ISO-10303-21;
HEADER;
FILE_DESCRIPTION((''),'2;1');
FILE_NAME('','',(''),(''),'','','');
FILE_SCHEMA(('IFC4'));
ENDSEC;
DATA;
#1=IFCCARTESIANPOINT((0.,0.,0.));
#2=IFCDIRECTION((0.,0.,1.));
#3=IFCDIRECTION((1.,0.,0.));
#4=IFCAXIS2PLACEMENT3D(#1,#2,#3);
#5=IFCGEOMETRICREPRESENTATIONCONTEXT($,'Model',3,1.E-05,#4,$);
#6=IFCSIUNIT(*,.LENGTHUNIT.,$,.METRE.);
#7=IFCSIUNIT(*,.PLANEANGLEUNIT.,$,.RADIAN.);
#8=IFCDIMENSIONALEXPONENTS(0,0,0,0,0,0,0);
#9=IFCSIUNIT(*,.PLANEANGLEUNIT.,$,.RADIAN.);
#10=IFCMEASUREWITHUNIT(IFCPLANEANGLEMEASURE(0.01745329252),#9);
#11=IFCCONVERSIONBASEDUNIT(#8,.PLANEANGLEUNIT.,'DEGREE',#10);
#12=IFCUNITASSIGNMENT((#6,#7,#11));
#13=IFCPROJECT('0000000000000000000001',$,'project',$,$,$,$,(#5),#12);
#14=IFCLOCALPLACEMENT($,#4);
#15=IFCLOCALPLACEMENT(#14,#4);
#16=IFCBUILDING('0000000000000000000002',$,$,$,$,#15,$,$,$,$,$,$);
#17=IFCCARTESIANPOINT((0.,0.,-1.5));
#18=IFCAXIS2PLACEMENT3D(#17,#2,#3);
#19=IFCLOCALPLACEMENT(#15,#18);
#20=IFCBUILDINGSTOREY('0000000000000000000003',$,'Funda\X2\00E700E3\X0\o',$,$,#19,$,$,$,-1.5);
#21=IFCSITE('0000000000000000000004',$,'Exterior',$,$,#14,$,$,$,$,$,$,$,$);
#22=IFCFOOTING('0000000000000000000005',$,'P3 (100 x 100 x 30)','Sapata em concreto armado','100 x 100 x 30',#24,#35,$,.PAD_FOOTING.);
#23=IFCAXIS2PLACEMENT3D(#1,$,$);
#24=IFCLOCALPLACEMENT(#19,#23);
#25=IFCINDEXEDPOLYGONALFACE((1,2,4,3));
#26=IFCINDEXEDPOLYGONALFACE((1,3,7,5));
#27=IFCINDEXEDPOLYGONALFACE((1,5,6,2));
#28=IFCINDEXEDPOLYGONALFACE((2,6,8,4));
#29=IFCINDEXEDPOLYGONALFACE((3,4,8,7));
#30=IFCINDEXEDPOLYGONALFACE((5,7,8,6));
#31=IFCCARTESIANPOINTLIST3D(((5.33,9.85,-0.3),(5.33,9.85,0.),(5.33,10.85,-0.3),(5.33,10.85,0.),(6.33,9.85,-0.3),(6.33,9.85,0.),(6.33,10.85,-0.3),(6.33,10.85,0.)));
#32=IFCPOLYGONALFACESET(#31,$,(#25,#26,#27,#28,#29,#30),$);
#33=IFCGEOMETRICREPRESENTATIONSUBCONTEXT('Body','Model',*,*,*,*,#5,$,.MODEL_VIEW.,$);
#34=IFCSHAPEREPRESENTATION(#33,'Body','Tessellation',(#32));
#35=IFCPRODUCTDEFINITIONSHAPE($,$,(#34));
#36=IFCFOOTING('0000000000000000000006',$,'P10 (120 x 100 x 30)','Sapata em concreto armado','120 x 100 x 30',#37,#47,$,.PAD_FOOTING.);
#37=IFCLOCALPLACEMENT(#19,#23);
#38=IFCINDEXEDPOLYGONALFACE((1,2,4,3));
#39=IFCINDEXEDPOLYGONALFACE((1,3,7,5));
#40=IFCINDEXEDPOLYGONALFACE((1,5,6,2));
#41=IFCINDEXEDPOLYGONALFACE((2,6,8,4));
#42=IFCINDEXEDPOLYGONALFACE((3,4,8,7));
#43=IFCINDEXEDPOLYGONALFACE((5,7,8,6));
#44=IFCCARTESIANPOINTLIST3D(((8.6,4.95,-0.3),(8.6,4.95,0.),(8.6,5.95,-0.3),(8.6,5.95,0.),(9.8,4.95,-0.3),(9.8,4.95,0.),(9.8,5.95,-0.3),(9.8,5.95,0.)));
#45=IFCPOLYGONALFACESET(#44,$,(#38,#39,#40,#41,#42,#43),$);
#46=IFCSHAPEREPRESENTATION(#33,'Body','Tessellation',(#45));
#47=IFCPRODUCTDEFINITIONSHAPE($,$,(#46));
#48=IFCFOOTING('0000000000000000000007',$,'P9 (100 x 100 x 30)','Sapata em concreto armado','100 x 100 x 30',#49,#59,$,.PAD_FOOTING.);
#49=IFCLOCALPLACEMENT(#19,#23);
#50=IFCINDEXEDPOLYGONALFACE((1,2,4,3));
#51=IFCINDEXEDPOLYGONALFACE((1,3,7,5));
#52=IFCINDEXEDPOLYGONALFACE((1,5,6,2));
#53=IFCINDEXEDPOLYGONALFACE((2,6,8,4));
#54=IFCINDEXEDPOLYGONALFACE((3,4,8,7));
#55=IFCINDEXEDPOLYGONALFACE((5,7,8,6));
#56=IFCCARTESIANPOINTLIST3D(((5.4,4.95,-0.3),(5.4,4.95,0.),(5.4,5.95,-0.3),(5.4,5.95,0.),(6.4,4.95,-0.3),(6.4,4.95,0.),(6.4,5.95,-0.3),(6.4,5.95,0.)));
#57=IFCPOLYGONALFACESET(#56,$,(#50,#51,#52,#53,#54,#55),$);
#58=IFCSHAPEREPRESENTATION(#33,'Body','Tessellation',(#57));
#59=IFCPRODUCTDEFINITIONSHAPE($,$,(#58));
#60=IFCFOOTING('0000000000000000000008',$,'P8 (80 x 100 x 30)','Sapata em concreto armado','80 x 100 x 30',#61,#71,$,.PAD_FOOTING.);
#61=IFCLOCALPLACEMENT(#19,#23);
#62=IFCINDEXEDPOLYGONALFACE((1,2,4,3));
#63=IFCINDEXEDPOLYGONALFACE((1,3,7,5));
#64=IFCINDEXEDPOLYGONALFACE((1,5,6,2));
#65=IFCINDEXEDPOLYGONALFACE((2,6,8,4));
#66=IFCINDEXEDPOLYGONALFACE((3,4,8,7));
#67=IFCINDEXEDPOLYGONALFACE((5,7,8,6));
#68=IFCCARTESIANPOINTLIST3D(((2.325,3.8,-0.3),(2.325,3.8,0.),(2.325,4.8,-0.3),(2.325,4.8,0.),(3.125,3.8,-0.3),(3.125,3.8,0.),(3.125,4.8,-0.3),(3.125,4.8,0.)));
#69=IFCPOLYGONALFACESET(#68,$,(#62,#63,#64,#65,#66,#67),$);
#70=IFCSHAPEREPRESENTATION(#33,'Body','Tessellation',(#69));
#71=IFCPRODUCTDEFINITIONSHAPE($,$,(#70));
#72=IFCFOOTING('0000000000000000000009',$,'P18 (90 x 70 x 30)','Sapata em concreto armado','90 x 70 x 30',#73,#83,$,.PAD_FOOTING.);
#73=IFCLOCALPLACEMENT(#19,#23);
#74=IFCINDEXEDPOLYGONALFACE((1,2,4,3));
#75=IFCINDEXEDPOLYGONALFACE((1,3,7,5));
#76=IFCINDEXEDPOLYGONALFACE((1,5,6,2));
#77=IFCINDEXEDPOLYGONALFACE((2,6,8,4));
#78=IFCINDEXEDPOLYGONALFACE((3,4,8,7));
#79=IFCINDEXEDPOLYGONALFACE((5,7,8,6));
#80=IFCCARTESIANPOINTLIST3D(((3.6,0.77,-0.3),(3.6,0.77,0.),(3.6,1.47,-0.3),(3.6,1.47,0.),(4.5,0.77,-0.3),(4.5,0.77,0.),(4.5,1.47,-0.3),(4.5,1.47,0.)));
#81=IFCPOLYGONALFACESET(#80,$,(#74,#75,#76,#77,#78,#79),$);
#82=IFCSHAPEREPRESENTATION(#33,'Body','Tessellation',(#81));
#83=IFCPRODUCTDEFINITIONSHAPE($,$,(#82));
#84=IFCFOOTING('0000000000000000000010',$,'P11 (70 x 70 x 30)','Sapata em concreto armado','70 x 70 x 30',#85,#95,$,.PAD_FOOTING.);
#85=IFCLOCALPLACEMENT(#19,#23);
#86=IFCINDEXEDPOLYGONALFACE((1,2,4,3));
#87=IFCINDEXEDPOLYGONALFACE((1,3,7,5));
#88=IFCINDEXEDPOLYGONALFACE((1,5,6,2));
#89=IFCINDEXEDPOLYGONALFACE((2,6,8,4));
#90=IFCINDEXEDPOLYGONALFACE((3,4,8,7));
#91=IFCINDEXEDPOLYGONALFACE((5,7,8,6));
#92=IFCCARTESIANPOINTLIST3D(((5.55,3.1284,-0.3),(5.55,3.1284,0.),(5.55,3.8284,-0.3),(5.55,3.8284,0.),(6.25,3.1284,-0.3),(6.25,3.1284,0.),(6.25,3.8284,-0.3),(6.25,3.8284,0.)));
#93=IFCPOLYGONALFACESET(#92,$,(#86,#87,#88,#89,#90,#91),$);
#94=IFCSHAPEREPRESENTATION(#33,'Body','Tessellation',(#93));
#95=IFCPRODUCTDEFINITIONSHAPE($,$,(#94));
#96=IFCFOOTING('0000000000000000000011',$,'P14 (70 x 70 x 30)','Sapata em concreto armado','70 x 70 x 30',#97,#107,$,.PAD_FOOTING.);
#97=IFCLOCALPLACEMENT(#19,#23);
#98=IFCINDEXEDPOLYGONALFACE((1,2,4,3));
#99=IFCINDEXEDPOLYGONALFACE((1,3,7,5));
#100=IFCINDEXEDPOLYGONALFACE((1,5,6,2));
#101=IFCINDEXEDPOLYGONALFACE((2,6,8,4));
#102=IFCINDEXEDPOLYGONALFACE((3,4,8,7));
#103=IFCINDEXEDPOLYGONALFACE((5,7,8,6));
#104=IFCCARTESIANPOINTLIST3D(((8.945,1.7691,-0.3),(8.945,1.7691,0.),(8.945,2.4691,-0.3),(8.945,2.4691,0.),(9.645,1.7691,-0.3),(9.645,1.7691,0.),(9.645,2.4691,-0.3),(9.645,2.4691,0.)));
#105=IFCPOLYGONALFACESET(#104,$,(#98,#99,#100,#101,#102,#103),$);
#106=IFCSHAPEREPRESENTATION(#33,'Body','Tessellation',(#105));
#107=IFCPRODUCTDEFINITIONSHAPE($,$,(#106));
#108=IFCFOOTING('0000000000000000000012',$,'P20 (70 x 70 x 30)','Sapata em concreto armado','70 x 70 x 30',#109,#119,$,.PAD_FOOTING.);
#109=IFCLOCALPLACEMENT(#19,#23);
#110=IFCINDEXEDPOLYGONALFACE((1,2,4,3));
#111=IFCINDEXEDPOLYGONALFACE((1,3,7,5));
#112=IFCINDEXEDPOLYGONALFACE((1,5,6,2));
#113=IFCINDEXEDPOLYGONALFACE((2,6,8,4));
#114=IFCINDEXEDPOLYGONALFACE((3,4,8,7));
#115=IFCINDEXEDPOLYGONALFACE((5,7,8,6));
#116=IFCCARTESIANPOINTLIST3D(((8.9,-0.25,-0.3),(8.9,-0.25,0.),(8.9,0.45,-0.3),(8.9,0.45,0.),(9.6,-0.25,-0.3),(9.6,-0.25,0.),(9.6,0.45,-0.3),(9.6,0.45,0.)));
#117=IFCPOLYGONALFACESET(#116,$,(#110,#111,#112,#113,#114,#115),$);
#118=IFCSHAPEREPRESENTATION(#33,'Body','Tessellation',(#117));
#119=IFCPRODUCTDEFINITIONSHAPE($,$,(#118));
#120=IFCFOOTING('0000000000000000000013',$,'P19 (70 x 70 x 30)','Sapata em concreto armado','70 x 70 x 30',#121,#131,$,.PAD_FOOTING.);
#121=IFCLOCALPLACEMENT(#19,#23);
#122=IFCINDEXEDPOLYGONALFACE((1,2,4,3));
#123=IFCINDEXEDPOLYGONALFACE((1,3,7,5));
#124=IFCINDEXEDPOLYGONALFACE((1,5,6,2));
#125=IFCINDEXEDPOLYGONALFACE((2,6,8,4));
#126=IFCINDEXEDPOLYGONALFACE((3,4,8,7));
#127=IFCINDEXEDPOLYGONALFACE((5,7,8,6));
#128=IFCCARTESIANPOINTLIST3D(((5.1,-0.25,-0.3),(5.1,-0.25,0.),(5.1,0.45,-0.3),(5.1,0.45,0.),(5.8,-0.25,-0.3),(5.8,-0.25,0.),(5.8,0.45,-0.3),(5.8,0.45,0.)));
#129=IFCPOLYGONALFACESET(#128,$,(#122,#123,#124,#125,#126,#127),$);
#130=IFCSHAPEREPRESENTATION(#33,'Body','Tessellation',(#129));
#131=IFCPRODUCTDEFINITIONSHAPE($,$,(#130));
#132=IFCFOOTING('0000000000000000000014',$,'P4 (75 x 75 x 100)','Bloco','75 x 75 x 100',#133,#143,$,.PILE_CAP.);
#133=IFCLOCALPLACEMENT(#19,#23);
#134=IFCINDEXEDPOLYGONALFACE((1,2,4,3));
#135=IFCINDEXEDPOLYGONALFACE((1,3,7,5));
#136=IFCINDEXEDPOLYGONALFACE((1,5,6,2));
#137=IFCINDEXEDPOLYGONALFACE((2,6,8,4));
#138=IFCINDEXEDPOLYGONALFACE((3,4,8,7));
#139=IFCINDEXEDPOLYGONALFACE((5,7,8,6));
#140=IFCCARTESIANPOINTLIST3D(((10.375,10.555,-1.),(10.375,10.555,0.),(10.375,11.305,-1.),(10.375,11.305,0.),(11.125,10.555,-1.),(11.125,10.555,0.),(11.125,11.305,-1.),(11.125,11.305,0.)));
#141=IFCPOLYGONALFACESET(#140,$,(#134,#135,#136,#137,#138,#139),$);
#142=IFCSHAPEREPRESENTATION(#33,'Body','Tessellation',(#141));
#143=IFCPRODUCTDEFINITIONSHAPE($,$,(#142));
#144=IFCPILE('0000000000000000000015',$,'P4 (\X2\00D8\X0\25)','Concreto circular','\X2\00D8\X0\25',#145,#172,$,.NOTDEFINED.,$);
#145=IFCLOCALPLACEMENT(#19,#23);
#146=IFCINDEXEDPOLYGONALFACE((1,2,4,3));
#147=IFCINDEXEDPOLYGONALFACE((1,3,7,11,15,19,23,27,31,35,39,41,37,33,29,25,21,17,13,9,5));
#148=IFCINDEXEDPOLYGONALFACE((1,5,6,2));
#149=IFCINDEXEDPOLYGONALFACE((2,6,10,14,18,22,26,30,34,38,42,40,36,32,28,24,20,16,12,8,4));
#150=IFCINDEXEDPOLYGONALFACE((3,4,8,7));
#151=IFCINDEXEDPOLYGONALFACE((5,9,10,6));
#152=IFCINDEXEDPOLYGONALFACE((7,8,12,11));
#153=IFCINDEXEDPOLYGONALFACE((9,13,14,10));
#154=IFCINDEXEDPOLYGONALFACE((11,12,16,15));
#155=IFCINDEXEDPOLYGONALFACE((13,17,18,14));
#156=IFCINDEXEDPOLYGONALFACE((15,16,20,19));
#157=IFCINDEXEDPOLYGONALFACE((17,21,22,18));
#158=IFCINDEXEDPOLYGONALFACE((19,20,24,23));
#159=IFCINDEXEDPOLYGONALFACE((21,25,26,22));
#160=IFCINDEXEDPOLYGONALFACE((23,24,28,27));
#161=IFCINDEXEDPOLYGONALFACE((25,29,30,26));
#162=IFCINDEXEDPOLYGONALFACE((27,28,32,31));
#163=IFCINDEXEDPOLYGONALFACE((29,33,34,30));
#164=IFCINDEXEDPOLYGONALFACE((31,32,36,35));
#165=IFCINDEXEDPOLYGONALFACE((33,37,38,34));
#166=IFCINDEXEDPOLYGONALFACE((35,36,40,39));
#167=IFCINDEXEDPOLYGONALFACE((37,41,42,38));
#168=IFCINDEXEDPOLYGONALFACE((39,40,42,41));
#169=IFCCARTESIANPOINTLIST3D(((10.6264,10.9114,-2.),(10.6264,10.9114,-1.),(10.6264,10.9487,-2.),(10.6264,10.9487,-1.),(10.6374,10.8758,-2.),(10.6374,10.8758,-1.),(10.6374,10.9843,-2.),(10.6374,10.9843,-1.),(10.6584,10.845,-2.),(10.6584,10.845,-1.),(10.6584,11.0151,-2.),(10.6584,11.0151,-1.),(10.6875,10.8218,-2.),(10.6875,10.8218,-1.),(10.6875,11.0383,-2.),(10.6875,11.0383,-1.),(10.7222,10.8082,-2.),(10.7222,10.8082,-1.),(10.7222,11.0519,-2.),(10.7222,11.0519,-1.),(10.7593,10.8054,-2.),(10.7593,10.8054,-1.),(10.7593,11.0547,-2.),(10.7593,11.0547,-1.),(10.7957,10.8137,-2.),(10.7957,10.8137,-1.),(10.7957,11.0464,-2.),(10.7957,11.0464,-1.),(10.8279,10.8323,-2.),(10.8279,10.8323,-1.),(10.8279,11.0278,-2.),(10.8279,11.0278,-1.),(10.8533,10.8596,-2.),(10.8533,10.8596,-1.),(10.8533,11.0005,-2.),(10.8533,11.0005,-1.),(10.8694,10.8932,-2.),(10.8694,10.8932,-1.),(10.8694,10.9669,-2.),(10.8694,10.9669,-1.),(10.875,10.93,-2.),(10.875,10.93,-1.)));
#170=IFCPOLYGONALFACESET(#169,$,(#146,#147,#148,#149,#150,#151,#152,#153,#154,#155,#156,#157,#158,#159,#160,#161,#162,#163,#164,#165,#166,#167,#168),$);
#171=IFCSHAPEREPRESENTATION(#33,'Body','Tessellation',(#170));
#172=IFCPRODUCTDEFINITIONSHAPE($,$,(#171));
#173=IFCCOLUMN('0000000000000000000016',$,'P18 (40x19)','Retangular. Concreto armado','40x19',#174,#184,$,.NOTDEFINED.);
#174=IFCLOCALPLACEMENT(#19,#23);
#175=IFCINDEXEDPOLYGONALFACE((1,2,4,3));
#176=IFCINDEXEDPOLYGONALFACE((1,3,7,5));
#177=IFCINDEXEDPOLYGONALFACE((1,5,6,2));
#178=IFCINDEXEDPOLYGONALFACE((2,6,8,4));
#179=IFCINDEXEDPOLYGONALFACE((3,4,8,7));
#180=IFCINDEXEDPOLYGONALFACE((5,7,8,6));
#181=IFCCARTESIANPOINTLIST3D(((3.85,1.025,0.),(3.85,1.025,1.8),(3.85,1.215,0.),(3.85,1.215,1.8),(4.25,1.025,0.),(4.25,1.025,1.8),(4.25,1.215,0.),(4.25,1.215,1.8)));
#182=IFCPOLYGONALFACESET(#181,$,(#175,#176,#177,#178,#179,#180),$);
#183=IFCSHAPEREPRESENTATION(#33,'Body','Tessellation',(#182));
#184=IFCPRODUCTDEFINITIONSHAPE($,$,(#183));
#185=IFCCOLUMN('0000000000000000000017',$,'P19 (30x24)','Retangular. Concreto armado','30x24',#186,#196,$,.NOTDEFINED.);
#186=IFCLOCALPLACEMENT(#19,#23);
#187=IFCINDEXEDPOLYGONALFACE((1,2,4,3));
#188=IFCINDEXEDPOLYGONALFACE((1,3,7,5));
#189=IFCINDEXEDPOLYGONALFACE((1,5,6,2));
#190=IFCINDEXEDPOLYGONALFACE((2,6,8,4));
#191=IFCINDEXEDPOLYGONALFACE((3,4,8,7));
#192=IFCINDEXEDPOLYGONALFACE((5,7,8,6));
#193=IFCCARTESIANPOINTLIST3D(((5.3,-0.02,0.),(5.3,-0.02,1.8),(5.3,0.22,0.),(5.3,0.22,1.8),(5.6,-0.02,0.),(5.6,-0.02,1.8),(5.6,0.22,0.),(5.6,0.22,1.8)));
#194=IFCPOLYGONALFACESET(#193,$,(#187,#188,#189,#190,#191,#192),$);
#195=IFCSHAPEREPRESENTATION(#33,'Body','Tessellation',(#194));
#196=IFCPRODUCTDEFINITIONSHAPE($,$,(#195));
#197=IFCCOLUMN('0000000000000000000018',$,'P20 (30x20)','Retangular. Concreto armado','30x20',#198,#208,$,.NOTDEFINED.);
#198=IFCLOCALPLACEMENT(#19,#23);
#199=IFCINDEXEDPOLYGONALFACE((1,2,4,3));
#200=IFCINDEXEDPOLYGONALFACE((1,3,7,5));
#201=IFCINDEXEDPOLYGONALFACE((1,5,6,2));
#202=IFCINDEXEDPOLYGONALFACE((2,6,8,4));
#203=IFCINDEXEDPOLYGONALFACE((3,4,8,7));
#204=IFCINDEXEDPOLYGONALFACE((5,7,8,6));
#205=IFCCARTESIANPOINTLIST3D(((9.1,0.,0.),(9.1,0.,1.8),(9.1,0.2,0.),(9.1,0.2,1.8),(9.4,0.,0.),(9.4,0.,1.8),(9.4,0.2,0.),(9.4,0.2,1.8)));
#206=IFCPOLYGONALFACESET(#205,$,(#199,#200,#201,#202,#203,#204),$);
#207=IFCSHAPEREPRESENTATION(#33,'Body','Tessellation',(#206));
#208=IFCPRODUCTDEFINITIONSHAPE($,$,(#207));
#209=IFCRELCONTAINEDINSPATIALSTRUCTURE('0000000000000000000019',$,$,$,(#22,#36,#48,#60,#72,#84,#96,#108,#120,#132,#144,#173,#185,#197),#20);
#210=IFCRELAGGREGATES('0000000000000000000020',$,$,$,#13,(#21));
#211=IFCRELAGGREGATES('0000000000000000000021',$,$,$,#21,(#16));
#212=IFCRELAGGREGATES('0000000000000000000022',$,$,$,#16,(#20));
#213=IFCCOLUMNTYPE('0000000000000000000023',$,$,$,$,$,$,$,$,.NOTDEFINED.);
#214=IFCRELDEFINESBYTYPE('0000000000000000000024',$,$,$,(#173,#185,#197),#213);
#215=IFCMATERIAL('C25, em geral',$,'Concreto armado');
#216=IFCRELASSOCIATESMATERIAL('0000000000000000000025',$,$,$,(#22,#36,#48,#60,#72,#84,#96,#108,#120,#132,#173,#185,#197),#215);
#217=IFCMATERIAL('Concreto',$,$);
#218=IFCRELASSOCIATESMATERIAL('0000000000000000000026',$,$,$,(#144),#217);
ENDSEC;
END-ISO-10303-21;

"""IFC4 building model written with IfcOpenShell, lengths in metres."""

from ifc_helpers import new_model, entity, si_unit, converted_unit, frame, frame_2d, origin_with_axes, origin_2d_with_axis, place, context, subcontext, project, spatial, rectangle, circle, extrude, material, type_object, element, save


model = new_model("IFC4")

# Units and contexts
model_context = context("Model", 3, precision=1e-05, world=origin_with_axes())
body_context = subcontext(model_context, "Body", "Model", "MODEL_VIEW")
ifc_project = project(units=[si_unit("LENGTHUNIT", "METRE"), si_unit("PLANEANGLEUNIT", "RADIAN"), converted_unit("PLANEANGLEUNIT", "DEGREE", entity("IfcPlaneAngleMeasure", 0.01745329252), si_unit("PLANEANGLEUNIT", "RADIAN"), dimensions=[0, 0, 0, 0, 0, 0, 0])], contexts=[model_context])

# Site, building, storey
site_placement = place(None, origin_with_axes())
site = spatial("IfcSite", under=ifc_project, at=site_placement, Name="Exterior")
building_placement = place(site_placement, origin_with_axes())
building = spatial("IfcBuilding", under=site, at=building_placement)
storey_placement = place(building_placement, frame((0.0, 0.0, -1.5), z_axis=(0.0, 0.0, 1.0), x_axis=(1.0, 0.0, 0.0)))
storey = spatial("IfcBuildingStorey", under=building, at=storey_placement, Name="Fundação", Elevation=-1.5)

# Footings
ifc_material_1 = material(Name="C25, em geral", Category="Concreto armado")
footing_1_placement = place(storey_placement, frame((5.83, 10.35, -0.3), z_axis=(0.0, 0.0, 1.0), x_axis=(1.0, 0.0, 0.0)))
element("IfcFooting", 1, at=footing_1_placement, inside=storey, material=ifc_material_1, Name="P3 (100 x 100 x 30)", Description="Sapata em concreto armado", ObjectType="100 x 100 x 30", PredefinedType="PAD_FOOTING", context=body_context, shape_type="SweptSolid", body=[
    extrude(rectangle(XDim=1.0, YDim=1.0, at=origin_2d_with_axis()), origin_with_axes(), (0.0, 0.0, 1.0), 0.3),
])
footing_2_placement = place(storey_placement, frame((9.2, 5.45, -0.3), z_axis=(0.0, 0.0, 1.0), x_axis=(1.0, 0.0, 0.0)))
element("IfcFooting", 2, at=footing_2_placement, inside=storey, material=ifc_material_1, Name="P10 (120 x 100 x 30)", Description="Sapata em concreto armado", ObjectType="120 x 100 x 30", PredefinedType="PAD_FOOTING", context=body_context, shape_type="SweptSolid", body=[
    extrude(rectangle(XDim=1.2, YDim=1.0, at=origin_2d_with_axis()), origin_with_axes(), (0.0, 0.0, 1.0), 0.3),
])
footing_3_placement = place(storey_placement, frame((5.9, 5.45, -0.3), z_axis=(0.0, 0.0, 1.0), x_axis=(1.0, 0.0, 0.0)))
element("IfcFooting", 3, at=footing_3_placement, inside=storey, material=ifc_material_1, Name="P9 (100 x 100 x 30)", Description="Sapata em concreto armado", ObjectType="100 x 100 x 30", PredefinedType="PAD_FOOTING", context=body_context, shape_type="SweptSolid", body=[
    extrude(rectangle(XDim=1.0, YDim=1.0, at=origin_2d_with_axis()), origin_with_axes(), (0.0, 0.0, 1.0), 0.3),
])
footing_4_placement = place(storey_placement, frame((2.725, 4.3, -0.3), z_axis=(0.0, 0.0, 1.0), x_axis=(1.0, 0.0, 0.0)))
element("IfcFooting", 4, at=footing_4_placement, inside=storey, material=ifc_material_1, Name="P8 (80 x 100 x 30)", Description="Sapata em concreto armado", ObjectType="80 x 100 x 30", PredefinedType="PAD_FOOTING", context=body_context, shape_type="SweptSolid", body=[
    extrude(rectangle(XDim=0.8, YDim=1.0, at=origin_2d_with_axis()), origin_with_axes(), (0.0, 0.0, 1.0), 0.3),
])
footing_5_placement = place(storey_placement, frame((4.05, 1.12, -0.3), z_axis=(0.0, 0.0, 1.0), x_axis=(1.0, 0.0, 0.0)))
element("IfcFooting", 5, at=footing_5_placement, inside=storey, material=ifc_material_1, Name="P18 (90 x 70 x 30)", Description="Sapata em concreto armado", ObjectType="90 x 70 x 30", PredefinedType="PAD_FOOTING", context=body_context, shape_type="SweptSolid", body=[
    extrude(rectangle(XDim=0.9, YDim=0.7, at=origin_2d_with_axis()), origin_with_axes(), (0.0, 0.0, 1.0), 0.3),
])
for number, where, z_axis, x_axis, name in (
    (6, (5.9, 3.4784, -0.3), (0.0, 0.0, 1.0), (1.0, 0.0, 0.0), "P11 (70 x 70 x 30)"),
    (7, (9.295, 2.1191, -0.3), (0.0, 0.0, 1.0), (1.0, 0.0, 0.0), "P14 (70 x 70 x 30)"),
    (8, (9.25, 0.1, -0.3), (0.0, 0.0, 1.0), (1.0, 0.0, 0.0), "P20 (70 x 70 x 30)"),
    (9, (5.45, 0.1, -0.3), (0.0, 0.0, 1.0), (1.0, 0.0, 0.0), "P19 (70 x 70 x 30)"),
):
    element("IfcFooting", number, at=place(storey_placement, frame(where, z_axis=z_axis, x_axis=x_axis)), inside=storey, material=ifc_material_1, Name=name, Description="Sapata em concreto armado", ObjectType="70 x 70 x 30", PredefinedType="PAD_FOOTING", context=body_context, shape_type="SweptSolid", body=[
        extrude(rectangle(XDim=0.7, YDim=0.7, at=origin_2d_with_axis()), origin_with_axes(), (0.0, 0.0, 1.0), 0.3),
    ])
footing_6_placement = place(storey_placement, frame((10.75, 10.93, -1.0), z_axis=(0.0, 0.0, 1.0), x_axis=(1.0, 0.0, 0.0)))
element("IfcFooting", 10, at=footing_6_placement, inside=storey, material=ifc_material_1, Name="P4 (75 x 75 x 100)", Description="Bloco", ObjectType="75 x 75 x 100", PredefinedType="PILE_CAP", context=body_context, shape_type="SweptSolid", body=[
    extrude(rectangle(XDim=0.75, YDim=0.75, at=origin_2d_with_axis()), origin_with_axes(), (0.0, 0.0, 1.0), 1.0),
])

# Pile
ifc_material_2 = material(Name="Concreto")
pile_placement = place(storey_placement, frame((10.75, 10.93, -1.0), z_axis=(0.0, 0.0, 1.0), x_axis=(1.0, 0.0, 0.0)))
element("IfcPile", 11, at=pile_placement, inside=storey, material=ifc_material_2, Name="P4 (Ø25)", Description="Concreto circular", ObjectType="Ø25", PredefinedType="NOTDEFINED", context=body_context, shape_type="SweptSolid", body=[
    extrude(circle(Radius=0.125, at=origin_2d_with_axis()), origin_with_axes(), (0.0, 0.0, -1.0), 1.0),
])

# Columns
column_type = type_object("IfcColumnType", PredefinedType="NOTDEFINED")
column_1_placement = place(storey_placement, frame((4.25, 1.12, 0.0), z_axis=(0.0, 0.0, 1.0), x_axis=(1.0, 0.0, 0.0)))
element("IfcColumn", 12, at=column_1_placement, inside=storey, type_object=column_type, material=ifc_material_1, Name="P18 (40x19)", Description="Retangular. Concreto armado", ObjectType="40x19", PredefinedType="NOTDEFINED", context=body_context, shape_type="SweptSolid", body=[
    extrude(rectangle(XDim=0.4, YDim=0.19, at=frame_2d((-0.2, 0.0), x_axis=(1.0, 0.0))), origin_with_axes(), (0.0, 0.0, 1.0), 1.8),
])
column_2_placement = place(storey_placement, frame((5.45, 0.1, 0.0), z_axis=(0.0, 0.0, 1.0), x_axis=(1.0, 0.0, 0.0)))
element("IfcColumn", 13, at=column_2_placement, inside=storey, type_object=column_type, material=ifc_material_1, Name="P19 (30x24)", Description="Retangular. Concreto armado", ObjectType="30x24", PredefinedType="NOTDEFINED", context=body_context, shape_type="SweptSolid", body=[
    extrude(rectangle(XDim=0.3, YDim=0.24, at=origin_2d_with_axis()), origin_with_axes(), (0.0, 0.0, 1.0), 1.8),
])
column_3_placement = place(storey_placement, frame((9.25, 0.1, 0.0), z_axis=(0.0, 0.0, 1.0), x_axis=(1.0, 0.0, 0.0)))
element("IfcColumn", 14, at=column_3_placement, inside=storey, type_object=column_type, material=ifc_material_1, Name="P20 (30x20)", Description="Retangular. Concreto armado", ObjectType="30x20", PredefinedType="NOTDEFINED", context=body_context, shape_type="SweptSolid", body=[
    extrude(rectangle(XDim=0.3, YDim=0.2, at=origin_2d_with_axis()), origin_with_axes(), (0.0, 0.0, 1.0), 1.8),
])

save(model, "model.ifc")
